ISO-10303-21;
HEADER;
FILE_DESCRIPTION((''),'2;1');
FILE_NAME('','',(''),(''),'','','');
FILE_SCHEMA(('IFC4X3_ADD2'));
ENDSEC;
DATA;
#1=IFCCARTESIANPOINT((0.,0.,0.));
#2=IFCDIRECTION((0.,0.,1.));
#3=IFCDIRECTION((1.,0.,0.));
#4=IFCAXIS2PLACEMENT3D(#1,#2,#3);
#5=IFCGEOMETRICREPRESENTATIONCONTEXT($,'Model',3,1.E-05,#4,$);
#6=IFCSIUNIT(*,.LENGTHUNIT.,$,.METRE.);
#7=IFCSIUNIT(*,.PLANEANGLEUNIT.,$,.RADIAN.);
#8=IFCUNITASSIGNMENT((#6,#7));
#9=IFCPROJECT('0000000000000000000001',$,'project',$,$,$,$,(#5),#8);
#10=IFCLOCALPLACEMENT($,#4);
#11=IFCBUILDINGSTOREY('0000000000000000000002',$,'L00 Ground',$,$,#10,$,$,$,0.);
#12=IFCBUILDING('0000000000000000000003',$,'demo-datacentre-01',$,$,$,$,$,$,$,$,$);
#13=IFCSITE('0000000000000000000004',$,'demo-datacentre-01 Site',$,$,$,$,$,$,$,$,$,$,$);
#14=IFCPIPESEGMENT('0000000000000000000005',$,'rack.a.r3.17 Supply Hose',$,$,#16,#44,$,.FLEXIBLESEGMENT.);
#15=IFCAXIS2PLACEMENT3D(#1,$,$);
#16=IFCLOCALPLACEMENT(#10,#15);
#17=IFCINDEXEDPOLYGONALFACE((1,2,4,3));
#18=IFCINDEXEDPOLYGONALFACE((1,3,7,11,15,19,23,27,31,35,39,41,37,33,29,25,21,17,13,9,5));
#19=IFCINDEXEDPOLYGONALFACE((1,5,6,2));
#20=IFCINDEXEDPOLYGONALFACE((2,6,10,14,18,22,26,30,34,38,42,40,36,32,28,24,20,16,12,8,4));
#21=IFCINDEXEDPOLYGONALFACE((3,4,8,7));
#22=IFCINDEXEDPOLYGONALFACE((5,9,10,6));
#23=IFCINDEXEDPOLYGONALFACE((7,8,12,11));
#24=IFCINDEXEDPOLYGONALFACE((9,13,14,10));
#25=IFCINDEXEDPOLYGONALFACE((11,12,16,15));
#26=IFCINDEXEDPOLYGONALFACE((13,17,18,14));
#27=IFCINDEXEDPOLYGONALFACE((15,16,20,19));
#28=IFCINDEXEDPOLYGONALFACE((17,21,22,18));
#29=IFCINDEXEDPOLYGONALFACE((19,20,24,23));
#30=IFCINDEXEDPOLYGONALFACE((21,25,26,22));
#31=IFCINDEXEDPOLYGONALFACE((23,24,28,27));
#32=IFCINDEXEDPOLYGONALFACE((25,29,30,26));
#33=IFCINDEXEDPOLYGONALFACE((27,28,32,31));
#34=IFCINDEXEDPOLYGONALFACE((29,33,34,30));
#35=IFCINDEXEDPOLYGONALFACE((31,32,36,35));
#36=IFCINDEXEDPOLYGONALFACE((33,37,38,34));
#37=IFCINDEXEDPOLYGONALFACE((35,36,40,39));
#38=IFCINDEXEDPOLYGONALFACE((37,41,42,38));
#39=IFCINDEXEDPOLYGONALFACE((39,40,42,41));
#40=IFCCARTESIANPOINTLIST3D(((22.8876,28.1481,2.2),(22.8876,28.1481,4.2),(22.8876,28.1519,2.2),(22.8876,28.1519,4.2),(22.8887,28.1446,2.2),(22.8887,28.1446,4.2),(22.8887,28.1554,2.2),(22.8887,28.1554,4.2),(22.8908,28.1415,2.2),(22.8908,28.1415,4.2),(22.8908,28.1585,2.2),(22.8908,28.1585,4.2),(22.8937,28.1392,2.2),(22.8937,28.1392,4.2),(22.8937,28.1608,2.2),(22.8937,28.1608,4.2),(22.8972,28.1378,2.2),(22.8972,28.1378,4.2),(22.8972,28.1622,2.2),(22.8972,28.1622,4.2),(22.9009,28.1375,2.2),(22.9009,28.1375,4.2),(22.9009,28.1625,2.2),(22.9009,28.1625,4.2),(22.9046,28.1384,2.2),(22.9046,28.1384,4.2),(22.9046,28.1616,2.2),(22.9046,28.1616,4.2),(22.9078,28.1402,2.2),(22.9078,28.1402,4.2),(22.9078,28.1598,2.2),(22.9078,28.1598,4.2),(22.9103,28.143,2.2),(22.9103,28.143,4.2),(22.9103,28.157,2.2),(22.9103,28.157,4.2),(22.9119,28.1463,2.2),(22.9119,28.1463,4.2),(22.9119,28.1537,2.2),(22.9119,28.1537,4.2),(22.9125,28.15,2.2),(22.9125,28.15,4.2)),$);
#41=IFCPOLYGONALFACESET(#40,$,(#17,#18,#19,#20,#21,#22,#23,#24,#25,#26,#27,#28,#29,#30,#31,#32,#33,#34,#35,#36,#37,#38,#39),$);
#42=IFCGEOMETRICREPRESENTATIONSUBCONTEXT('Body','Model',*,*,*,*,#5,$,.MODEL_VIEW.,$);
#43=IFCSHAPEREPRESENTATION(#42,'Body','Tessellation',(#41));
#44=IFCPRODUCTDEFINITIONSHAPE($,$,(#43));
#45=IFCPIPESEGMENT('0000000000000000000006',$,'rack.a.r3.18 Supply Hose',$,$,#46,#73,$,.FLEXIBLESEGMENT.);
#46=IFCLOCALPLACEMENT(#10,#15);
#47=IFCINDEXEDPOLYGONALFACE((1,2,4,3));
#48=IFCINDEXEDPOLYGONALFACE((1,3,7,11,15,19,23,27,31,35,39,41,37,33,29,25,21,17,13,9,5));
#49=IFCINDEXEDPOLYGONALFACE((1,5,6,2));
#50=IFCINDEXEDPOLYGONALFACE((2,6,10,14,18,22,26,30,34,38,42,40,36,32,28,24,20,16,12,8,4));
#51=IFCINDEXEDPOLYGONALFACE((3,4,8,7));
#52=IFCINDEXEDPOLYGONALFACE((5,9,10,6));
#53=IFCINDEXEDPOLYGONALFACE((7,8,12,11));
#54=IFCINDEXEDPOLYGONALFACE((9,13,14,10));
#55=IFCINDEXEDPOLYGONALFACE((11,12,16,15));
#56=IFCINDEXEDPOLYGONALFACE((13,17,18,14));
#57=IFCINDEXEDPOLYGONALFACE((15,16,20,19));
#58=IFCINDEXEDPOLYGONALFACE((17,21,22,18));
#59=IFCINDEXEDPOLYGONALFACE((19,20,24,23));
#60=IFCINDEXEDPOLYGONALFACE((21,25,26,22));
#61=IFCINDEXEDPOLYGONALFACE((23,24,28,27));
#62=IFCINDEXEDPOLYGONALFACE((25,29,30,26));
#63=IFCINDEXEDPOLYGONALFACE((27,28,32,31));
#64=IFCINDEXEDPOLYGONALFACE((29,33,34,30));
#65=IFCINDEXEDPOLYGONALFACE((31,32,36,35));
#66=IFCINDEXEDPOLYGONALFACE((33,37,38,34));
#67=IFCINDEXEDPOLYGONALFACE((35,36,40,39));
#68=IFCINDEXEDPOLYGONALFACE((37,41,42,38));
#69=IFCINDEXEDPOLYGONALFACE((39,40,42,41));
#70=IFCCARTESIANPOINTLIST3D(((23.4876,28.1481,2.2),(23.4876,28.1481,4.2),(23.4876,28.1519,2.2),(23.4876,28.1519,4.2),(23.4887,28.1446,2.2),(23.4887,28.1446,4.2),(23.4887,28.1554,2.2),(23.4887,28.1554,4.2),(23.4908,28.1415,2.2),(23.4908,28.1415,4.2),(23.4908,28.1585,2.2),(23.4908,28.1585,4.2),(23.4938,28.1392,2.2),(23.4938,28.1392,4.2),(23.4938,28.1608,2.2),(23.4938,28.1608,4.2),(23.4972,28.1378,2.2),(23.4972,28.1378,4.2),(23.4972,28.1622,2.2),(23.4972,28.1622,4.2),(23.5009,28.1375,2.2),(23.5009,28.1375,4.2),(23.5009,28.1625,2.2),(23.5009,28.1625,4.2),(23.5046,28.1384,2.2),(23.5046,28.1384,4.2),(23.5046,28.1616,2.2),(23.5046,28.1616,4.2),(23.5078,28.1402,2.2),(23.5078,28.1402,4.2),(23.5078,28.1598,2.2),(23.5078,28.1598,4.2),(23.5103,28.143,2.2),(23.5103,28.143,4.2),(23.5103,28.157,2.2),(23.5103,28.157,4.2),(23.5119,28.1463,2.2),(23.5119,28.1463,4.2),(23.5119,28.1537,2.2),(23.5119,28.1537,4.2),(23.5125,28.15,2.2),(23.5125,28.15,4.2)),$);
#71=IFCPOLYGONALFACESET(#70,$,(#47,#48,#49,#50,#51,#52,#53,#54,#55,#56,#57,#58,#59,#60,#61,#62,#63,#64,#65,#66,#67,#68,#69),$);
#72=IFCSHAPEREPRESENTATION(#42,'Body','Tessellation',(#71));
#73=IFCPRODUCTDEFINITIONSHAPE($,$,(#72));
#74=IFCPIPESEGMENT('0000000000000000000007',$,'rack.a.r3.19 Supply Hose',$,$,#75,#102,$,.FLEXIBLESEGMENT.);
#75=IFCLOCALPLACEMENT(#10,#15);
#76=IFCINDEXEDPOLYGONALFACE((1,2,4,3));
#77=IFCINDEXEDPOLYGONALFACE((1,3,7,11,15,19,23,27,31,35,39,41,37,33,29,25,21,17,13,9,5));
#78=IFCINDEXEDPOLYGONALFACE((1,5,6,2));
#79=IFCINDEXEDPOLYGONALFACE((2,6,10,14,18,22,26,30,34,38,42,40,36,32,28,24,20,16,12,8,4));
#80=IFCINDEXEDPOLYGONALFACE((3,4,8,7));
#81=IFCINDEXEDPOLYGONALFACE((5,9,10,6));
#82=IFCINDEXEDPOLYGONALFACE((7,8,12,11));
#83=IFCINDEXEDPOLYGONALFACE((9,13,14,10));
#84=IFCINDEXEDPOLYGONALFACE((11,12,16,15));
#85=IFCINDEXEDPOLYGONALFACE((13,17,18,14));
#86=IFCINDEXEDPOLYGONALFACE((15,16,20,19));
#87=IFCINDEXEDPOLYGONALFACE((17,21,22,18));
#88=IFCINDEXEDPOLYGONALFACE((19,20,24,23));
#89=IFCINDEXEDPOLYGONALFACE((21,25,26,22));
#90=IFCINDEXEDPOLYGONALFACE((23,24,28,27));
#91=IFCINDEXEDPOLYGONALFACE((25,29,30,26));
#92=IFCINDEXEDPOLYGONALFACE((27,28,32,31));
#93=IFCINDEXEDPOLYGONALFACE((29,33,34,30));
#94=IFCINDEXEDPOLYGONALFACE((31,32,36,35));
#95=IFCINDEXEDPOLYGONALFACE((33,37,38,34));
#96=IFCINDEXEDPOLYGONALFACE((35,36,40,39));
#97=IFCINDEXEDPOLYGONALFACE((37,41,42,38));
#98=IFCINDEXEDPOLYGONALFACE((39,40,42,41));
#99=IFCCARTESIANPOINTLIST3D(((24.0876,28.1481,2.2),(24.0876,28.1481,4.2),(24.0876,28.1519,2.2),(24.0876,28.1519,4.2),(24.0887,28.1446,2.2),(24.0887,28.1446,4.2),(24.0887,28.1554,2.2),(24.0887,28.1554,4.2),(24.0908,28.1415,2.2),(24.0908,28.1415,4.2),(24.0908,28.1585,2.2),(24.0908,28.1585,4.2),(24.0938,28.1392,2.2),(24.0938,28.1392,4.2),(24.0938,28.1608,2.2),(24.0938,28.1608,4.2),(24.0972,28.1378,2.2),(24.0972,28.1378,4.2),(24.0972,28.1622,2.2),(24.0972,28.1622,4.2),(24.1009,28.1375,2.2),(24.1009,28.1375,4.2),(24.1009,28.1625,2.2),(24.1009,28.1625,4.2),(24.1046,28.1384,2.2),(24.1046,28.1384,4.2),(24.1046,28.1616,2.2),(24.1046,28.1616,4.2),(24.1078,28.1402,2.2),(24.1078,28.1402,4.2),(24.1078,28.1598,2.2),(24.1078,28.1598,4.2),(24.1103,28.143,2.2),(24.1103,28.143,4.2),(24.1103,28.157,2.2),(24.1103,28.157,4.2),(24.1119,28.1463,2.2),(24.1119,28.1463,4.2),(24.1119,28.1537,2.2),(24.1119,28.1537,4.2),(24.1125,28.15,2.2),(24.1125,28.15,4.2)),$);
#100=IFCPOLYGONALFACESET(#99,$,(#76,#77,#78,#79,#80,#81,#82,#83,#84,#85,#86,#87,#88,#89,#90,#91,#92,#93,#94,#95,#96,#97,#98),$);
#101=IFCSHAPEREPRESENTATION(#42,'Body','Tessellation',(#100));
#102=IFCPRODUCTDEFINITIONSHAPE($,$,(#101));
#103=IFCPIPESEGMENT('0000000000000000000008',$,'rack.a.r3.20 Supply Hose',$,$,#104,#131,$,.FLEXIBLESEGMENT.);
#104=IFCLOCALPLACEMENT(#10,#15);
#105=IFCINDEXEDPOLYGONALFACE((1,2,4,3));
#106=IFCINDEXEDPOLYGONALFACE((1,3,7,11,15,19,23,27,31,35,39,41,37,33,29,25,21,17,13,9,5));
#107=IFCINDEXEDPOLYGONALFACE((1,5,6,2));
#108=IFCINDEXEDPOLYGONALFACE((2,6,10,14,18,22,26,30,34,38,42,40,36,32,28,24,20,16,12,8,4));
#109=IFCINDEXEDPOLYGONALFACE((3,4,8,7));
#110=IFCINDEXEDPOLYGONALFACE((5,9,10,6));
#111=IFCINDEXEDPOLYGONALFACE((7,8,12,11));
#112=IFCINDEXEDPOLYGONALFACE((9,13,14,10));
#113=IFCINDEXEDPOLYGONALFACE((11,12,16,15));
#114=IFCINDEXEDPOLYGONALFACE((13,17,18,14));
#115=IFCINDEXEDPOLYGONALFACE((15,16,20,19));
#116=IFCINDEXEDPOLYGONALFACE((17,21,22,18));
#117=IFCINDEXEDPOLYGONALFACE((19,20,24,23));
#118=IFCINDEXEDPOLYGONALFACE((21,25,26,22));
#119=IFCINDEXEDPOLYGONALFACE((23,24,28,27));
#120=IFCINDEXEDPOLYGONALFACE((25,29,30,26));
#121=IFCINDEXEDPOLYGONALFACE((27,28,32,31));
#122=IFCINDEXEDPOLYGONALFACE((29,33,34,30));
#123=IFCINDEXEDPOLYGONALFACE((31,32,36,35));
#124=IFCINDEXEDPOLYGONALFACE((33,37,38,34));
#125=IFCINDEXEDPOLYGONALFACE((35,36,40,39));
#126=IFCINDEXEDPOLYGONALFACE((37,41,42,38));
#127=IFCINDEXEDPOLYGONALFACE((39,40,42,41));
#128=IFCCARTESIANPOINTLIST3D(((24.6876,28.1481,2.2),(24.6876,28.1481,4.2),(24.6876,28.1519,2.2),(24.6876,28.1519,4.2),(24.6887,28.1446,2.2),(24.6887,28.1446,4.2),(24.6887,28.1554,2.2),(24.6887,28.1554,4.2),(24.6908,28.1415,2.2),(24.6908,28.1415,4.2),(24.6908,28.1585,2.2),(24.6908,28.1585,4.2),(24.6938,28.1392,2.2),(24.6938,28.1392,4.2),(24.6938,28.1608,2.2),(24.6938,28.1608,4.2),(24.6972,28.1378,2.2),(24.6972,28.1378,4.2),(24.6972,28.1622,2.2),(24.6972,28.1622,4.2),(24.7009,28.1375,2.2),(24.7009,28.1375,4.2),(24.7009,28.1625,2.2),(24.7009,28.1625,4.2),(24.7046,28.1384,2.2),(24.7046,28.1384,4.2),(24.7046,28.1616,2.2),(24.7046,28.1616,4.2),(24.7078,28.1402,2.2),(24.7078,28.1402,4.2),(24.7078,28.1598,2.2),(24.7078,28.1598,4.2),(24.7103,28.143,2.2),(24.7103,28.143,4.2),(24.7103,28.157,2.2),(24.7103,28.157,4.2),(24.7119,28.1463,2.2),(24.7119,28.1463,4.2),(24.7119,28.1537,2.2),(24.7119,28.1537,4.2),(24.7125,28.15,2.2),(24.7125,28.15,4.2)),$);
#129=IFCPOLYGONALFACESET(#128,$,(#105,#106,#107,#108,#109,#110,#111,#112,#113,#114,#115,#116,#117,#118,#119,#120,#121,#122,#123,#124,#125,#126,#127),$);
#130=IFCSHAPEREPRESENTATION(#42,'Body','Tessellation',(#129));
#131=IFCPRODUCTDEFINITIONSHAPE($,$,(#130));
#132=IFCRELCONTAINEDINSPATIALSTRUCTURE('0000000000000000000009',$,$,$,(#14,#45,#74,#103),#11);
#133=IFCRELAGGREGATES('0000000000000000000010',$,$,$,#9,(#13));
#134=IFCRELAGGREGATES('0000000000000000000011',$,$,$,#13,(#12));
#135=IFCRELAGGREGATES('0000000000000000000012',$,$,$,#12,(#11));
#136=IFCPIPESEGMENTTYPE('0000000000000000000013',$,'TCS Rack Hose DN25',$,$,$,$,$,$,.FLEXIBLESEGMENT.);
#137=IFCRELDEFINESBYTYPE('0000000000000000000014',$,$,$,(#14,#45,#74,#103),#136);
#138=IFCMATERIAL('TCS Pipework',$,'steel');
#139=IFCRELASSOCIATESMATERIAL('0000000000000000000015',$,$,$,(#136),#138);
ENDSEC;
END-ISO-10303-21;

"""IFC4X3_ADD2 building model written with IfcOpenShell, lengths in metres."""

from ifc_helpers import new_model, si_unit, frame, origin_with_axes, place, context, subcontext, project, spatial, circle, extrude, material, type_object, element, save


model = new_model("IFC4X3_ADD2")

# Units and contexts
model_context = context("Model", 3, precision=1e-05, world=origin_with_axes())
body_context = subcontext(model_context, "Body", "Model", "MODEL_VIEW")
ifc_project = project(units=[si_unit("LENGTHUNIT", "METRE"), si_unit("PLANEANGLEUNIT", "RADIAN")], contexts=[model_context])

# Site, building, storey
site = spatial("IfcSite", under=ifc_project, Name="demo-datacentre-01 Site")
building = spatial("IfcBuilding", under=site, Name="demo-datacentre-01")
storey_placement = place(None, origin_with_axes())
storey = spatial("IfcBuildingStorey", under=building, at=storey_placement, Name="L00 Ground", Elevation=0.0)

# Shared definitions
ifc_material = material(Name="TCS Pipework", Category="steel")

# Pipe segments
pipe_segment_type_1 = type_object("IfcPipeSegmentType", Name="TCS Rack Hose DN25", PredefinedType="FLEXIBLESEGMENT", material=ifc_material)
for number, where, z_axis, x_axis, name in (
    (1, (22.9, 28.15, 4.2), (0.0, 0.0, -1.0), (1.0, 0.0, 0.0), "rack.a.r3.17 Supply Hose"),
    (2, (23.5, 28.15, 4.2), (0.0, 0.0, -1.0), (1.0, 0.0, 0.0), "rack.a.r3.18 Supply Hose"),
    (3, (24.1, 28.15, 4.2), (0.0, 0.0, -1.0), (1.0, 0.0, 0.0), "rack.a.r3.19 Supply Hose"),
    (4, (24.7, 28.15, 4.2), (0.0, 0.0, -1.0), (1.0, 0.0, 0.0), "rack.a.r3.20 Supply Hose"),
):
    element("IfcPipeSegment", number, at=place(storey_placement, frame(where, z_axis=z_axis, x_axis=x_axis)), inside=storey, type_object=pipe_segment_type_1, Name=name, PredefinedType="FLEXIBLESEGMENT", context=body_context, shape_type="SweptSolid", body=[
        extrude(circle(Radius=0.0125), origin_with_axes(), (0.0, 0.0, 1.0), 2.0),
    ])

save(model, "model.ifc")
